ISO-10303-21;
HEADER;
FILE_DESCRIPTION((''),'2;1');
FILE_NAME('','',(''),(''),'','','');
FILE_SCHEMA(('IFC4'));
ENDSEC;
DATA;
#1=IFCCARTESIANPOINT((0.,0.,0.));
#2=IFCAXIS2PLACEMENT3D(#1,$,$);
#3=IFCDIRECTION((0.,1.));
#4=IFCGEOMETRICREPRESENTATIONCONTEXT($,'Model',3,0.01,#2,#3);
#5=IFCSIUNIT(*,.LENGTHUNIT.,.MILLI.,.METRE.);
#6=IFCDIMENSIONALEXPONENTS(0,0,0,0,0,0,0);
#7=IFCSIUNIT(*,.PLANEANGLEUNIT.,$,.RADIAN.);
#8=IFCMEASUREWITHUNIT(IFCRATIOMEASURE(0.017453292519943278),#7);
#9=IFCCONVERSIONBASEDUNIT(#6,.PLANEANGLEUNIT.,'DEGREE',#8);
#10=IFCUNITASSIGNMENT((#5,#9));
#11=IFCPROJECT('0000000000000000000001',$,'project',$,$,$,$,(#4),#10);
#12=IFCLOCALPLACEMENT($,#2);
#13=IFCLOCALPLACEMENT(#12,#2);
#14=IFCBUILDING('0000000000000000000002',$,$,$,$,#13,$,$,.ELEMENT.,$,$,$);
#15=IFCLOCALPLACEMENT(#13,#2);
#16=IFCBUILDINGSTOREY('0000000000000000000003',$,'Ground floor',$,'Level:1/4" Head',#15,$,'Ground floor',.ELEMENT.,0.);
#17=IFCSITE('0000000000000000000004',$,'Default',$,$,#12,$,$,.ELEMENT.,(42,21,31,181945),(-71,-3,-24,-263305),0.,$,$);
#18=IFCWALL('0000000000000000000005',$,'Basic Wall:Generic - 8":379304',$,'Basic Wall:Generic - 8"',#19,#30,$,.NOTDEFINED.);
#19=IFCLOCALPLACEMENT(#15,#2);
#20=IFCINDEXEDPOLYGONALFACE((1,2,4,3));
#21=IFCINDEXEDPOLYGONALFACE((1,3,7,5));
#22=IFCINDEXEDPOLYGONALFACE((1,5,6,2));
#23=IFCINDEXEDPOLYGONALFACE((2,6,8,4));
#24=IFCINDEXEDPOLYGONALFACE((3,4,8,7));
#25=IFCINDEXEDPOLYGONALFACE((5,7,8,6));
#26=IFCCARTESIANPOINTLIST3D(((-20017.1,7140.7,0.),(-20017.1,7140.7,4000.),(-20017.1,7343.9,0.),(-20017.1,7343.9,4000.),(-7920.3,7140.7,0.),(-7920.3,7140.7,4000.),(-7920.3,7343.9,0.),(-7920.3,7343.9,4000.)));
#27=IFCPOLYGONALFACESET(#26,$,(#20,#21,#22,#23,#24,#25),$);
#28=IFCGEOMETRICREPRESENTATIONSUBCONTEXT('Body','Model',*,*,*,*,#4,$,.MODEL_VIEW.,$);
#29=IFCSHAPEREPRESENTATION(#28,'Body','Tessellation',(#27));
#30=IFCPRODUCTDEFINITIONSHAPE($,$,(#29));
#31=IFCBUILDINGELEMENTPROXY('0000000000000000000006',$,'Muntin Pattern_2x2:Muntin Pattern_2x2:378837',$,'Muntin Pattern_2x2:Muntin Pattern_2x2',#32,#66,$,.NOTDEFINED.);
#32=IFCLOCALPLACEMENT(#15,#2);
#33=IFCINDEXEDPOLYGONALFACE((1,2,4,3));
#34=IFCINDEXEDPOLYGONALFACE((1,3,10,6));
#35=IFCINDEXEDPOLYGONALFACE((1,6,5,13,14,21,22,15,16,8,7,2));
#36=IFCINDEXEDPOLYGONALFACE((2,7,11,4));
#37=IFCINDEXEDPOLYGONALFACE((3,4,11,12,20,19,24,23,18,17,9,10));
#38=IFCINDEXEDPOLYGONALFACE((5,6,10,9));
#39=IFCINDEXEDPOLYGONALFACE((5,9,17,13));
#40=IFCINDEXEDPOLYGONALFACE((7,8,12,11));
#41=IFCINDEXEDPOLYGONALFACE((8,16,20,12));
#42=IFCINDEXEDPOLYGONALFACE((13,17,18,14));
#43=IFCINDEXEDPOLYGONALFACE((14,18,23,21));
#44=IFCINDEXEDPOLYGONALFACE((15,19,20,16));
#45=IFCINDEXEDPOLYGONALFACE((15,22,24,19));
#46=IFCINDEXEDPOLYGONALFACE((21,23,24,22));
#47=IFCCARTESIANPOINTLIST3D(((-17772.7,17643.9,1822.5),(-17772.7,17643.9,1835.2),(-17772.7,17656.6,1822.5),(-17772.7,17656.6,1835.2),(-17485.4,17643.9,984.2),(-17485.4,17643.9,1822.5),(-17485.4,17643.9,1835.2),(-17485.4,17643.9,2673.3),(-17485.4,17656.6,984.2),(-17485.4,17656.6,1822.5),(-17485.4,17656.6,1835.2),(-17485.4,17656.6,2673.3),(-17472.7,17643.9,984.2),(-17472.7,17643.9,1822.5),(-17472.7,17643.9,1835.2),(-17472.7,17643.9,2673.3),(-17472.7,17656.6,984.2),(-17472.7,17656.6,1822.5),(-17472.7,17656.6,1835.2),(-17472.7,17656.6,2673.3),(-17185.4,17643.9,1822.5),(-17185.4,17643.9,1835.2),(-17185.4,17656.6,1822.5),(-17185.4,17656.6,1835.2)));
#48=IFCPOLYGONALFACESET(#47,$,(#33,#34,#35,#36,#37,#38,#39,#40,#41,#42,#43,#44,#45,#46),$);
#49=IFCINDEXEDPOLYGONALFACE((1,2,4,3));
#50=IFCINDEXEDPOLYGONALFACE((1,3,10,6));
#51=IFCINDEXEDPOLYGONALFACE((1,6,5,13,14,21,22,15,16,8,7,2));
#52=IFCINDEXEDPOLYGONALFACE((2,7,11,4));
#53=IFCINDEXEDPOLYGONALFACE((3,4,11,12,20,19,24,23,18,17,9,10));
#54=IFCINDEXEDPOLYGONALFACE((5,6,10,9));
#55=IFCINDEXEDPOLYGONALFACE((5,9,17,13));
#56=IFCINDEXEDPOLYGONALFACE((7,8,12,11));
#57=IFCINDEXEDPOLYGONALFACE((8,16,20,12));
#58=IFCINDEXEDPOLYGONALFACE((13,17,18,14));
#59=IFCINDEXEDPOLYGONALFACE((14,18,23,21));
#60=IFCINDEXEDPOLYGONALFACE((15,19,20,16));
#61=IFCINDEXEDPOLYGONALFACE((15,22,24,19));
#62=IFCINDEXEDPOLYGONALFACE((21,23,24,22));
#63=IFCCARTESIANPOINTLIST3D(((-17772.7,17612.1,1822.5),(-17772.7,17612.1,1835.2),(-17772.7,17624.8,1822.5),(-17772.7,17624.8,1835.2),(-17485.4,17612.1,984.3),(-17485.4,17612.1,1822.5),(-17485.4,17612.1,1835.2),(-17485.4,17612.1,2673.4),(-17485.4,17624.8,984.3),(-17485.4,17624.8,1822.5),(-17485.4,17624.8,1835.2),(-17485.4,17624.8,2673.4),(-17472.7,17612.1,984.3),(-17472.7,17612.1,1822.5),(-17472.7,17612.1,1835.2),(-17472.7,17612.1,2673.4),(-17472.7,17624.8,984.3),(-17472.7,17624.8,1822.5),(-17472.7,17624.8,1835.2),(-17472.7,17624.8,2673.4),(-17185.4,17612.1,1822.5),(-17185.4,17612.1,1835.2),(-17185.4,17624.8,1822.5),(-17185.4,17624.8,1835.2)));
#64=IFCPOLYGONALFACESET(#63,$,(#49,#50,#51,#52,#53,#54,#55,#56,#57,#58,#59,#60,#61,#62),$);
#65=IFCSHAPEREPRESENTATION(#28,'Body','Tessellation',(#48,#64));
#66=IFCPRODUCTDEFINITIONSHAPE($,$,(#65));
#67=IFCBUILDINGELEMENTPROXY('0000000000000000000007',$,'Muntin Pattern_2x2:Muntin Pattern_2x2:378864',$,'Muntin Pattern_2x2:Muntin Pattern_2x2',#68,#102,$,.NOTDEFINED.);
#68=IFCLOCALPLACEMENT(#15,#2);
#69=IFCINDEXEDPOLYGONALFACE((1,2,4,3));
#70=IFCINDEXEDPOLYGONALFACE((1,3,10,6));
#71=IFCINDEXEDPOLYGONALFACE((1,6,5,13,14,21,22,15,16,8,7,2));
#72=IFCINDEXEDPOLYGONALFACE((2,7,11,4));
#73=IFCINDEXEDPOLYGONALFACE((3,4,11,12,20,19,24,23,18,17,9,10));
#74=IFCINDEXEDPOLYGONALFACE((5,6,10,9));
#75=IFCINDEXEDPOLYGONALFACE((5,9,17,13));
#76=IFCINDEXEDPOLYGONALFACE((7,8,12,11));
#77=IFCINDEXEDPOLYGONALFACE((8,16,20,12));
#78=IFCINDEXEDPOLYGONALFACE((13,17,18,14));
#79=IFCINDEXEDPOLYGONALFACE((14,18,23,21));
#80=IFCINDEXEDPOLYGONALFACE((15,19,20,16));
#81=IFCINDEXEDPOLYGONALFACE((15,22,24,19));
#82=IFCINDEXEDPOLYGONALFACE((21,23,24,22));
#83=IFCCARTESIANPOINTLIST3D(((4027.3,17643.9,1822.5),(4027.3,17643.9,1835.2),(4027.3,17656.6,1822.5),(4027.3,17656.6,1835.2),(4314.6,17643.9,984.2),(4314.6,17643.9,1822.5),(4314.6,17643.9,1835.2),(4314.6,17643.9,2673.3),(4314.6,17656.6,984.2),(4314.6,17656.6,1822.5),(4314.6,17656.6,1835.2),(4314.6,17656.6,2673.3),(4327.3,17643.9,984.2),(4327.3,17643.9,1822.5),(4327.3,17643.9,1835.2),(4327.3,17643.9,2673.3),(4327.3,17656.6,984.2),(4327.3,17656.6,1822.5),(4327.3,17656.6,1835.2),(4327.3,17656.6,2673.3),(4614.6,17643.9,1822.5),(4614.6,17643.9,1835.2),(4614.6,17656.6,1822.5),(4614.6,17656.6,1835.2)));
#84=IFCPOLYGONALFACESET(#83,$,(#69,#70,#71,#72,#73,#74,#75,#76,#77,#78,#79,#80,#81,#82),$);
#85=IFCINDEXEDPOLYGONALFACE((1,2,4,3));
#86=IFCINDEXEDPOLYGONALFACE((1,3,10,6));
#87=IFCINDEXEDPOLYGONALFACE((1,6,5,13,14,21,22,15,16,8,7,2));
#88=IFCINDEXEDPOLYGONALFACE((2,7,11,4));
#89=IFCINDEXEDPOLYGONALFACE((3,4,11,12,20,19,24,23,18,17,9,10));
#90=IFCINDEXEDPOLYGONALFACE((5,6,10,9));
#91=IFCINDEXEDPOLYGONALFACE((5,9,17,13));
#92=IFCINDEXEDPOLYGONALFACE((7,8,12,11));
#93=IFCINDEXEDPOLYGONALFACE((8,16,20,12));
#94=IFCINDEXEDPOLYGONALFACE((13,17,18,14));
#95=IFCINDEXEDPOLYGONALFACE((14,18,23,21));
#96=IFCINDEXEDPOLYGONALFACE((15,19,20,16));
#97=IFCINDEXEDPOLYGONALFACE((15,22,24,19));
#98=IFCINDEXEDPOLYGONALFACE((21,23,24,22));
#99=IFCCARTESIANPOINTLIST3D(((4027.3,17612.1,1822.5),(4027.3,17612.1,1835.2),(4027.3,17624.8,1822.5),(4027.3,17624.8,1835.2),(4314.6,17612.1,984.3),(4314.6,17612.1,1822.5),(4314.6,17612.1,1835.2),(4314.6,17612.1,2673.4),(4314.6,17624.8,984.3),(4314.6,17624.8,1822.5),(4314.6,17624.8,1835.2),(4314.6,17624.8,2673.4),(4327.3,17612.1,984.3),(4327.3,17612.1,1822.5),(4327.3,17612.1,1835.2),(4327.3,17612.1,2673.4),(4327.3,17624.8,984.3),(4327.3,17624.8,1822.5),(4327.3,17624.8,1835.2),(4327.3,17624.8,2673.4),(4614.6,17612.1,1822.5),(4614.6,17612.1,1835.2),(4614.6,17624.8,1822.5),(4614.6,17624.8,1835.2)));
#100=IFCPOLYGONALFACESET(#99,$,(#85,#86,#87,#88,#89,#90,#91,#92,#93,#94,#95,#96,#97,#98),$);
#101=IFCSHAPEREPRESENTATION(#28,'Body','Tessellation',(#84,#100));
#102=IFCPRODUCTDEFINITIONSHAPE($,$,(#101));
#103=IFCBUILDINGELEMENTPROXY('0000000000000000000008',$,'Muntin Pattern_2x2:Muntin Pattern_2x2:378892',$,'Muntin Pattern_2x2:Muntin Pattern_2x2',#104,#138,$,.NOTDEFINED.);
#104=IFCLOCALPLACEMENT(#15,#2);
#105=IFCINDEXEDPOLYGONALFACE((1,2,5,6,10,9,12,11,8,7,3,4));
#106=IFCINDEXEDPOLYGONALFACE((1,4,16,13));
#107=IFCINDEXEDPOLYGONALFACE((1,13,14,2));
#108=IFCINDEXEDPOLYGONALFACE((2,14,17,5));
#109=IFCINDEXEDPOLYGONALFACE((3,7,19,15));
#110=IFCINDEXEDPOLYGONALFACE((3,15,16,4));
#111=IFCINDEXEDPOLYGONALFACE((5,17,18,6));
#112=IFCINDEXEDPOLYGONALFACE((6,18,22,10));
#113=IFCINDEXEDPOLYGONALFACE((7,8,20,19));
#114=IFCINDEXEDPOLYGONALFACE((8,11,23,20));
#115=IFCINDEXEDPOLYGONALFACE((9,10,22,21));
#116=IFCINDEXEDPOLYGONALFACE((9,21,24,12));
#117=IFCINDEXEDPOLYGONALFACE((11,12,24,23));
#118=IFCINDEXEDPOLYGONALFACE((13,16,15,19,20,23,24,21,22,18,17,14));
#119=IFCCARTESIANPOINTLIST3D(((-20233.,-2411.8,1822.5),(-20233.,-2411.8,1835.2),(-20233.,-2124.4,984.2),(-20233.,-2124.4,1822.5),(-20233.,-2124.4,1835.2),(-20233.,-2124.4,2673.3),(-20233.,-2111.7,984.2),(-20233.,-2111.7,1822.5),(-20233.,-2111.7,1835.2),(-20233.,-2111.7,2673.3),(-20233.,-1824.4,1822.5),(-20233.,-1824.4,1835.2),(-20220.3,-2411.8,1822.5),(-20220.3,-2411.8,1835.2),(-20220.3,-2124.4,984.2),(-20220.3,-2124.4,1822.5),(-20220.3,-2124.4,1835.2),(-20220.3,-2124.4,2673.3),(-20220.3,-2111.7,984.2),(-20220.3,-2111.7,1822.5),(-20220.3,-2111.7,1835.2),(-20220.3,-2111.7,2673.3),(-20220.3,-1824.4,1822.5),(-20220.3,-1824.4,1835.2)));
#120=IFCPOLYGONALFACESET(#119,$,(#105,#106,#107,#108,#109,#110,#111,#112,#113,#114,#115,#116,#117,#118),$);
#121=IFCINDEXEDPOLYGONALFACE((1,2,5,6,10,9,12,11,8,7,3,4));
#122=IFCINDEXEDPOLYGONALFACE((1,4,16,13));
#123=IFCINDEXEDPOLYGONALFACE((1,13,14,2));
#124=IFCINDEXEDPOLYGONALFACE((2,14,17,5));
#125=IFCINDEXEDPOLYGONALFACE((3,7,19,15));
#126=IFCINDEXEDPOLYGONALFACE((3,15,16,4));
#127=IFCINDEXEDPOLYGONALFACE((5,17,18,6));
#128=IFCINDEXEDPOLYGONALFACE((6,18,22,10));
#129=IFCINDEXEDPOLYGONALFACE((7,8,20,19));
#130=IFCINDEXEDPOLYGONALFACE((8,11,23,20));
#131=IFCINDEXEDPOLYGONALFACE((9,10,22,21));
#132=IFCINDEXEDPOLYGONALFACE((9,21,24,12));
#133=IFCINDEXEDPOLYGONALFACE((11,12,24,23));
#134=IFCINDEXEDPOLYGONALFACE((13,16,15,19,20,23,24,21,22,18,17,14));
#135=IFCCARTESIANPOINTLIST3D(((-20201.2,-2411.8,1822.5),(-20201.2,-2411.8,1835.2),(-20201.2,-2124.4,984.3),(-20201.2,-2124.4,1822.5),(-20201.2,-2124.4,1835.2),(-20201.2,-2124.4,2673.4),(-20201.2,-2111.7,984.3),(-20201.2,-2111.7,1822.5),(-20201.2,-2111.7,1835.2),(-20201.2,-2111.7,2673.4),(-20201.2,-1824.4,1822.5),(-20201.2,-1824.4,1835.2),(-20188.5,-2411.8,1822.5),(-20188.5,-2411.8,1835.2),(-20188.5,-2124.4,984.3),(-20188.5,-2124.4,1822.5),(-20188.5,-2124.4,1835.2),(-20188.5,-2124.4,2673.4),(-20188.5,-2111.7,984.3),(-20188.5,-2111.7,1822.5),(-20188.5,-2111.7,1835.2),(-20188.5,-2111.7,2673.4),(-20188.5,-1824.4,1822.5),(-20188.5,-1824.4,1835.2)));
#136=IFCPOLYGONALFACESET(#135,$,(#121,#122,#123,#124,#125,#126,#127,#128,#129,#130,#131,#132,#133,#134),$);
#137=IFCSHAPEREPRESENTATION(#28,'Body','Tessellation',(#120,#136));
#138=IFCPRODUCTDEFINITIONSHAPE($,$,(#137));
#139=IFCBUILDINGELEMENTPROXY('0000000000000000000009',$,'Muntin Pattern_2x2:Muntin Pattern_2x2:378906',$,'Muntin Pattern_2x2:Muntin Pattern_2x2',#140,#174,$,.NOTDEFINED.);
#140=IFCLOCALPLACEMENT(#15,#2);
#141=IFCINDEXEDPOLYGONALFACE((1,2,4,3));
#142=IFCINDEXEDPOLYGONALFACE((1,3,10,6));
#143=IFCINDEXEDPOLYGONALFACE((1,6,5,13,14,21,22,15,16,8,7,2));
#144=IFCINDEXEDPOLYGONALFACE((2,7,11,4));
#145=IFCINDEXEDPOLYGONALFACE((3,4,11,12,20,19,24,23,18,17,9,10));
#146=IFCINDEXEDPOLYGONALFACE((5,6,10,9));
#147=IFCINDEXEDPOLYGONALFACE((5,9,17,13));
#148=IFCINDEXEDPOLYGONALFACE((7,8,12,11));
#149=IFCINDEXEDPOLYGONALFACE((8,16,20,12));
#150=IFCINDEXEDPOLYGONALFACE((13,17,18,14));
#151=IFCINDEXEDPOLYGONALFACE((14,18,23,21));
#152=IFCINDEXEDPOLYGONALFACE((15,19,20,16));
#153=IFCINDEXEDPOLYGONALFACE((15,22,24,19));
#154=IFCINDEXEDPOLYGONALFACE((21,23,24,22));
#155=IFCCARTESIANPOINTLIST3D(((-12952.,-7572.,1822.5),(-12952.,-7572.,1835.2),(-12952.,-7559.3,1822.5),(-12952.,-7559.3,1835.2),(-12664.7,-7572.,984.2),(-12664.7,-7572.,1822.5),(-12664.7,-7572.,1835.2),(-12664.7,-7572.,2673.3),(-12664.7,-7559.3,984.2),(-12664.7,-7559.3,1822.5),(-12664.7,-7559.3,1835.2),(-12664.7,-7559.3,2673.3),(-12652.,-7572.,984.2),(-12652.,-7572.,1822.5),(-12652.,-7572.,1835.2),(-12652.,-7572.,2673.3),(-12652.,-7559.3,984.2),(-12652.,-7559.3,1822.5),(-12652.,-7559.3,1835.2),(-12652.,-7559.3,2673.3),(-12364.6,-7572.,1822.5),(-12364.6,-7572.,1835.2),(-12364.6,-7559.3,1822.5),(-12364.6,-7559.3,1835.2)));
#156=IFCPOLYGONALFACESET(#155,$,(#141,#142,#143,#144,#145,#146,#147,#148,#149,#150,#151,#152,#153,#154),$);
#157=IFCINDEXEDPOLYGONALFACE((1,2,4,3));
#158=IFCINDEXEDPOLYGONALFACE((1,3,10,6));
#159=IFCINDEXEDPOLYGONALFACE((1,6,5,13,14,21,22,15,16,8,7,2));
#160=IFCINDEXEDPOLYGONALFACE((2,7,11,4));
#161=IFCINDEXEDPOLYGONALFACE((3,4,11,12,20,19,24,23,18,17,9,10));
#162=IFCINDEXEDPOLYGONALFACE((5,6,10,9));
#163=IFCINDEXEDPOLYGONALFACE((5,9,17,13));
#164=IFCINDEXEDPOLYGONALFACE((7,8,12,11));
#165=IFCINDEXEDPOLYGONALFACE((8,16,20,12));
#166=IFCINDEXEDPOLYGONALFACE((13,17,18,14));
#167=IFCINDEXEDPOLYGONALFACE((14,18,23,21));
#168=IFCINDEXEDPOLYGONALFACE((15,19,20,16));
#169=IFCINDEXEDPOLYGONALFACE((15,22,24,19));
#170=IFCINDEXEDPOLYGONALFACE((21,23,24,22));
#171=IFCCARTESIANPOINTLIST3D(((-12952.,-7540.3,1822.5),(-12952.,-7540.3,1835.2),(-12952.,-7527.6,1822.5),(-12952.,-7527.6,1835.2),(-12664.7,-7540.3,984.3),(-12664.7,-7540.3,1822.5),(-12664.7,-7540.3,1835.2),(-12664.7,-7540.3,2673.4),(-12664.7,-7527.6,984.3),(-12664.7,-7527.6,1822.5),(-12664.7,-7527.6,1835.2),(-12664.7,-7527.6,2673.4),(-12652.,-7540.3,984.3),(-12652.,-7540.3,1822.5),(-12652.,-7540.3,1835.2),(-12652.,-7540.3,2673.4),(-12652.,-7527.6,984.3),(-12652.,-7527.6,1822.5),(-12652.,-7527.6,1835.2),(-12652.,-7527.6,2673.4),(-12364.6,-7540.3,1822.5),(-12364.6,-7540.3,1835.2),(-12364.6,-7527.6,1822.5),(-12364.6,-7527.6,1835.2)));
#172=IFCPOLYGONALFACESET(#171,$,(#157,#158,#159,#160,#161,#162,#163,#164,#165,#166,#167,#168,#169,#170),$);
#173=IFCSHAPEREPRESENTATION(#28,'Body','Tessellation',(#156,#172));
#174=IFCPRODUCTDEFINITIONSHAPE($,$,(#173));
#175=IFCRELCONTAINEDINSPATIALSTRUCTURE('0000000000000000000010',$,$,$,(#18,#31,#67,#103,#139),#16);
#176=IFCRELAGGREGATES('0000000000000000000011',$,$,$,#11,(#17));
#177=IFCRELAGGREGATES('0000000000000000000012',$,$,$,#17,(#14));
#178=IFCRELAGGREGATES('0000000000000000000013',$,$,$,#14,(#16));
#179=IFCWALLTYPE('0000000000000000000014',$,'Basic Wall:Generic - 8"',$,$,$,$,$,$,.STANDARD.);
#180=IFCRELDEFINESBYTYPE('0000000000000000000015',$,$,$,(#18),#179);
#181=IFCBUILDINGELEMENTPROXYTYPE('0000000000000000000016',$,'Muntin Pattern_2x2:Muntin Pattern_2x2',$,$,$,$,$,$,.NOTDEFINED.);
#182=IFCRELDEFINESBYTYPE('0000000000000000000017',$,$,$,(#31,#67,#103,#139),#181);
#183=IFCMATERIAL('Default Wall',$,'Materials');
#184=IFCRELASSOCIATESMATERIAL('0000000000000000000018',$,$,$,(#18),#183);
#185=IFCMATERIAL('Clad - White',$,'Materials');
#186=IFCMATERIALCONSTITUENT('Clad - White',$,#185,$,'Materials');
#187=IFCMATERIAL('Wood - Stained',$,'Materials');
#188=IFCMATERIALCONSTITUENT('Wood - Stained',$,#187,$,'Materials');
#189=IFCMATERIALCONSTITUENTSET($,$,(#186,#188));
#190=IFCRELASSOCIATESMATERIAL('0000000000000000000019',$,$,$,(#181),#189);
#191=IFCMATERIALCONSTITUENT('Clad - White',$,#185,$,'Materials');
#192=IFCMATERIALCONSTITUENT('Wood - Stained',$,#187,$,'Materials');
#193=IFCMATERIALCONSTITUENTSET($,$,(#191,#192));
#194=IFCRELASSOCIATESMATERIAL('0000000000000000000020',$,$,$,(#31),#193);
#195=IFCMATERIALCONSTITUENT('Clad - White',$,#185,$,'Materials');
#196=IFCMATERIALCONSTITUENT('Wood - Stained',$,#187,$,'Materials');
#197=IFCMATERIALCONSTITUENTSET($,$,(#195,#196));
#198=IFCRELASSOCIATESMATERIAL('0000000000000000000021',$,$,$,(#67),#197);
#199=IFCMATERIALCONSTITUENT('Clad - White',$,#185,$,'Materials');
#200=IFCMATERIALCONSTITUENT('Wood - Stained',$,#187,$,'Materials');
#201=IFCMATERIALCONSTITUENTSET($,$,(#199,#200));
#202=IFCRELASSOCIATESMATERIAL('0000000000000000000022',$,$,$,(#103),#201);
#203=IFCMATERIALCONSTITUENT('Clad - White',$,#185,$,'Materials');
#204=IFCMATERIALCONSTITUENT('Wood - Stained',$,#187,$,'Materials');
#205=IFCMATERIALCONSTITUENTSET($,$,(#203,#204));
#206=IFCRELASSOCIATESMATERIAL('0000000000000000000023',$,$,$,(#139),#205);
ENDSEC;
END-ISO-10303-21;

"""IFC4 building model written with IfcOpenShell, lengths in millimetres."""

from ifc_helpers import new_model, entity, si_unit, converted_unit, direction, frame, origin, place, context, subcontext, project, spatial, indexed_curve, outline, extrude, source, transform, mapped, material, constituent, constituent_set, type_object, type_shapes, element, save


model = new_model("IFC4")

# Units and contexts
model_context = context("Model", 3, precision=0.01, world=origin(), true_north=direction((0.0, 1.0)))
body_context = subcontext(model_context, "Body", "Model", "MODEL_VIEW")
ifc_project = project(units=[si_unit("LENGTHUNIT", "METRE", prefix="MILLI"), converted_unit("PLANEANGLEUNIT", "DEGREE", entity("IfcRatioMeasure", 0.017453292519943278), si_unit("PLANEANGLEUNIT", "RADIAN"), dimensions=[0, 0, 0, 0, 0, 0, 0])], contexts=[model_context])

# Site, building, storey
site_placement = place(None, origin())
site = spatial("IfcSite", under=ifc_project, at=site_placement, Name="Default", CompositionType="ELEMENT", RefLatitude=(42, 21, 31, 181945), RefLongitude=(-71, -3, -24, -263305), RefElevation=0.0)
building_placement = place(site_placement, origin())
building = spatial("IfcBuilding", under=site, at=building_placement, CompositionType="ELEMENT")
storey_placement = place(building_placement, origin())
storey = spatial("IfcBuildingStorey", under=building, at=storey_placement, Name="Ground floor", ObjectType="Level:1/4\" Head", LongName="Ground floor", CompositionType="ELEMENT", Elevation=0.0)

# Wall
ifc_material_1 = material(Name="Default Wall", Category="Materials")
wall_type = type_object("IfcWallType", Name="Basic Wall:Generic - 8\"", PredefinedType="STANDARD")
wall_placement = place(storey_placement, frame((-20017.1, 7242.3, 0.0)))
element("IfcWall", 1, at=wall_placement, inside=storey, type_object=wall_type, material=ifc_material_1, Name="Basic Wall:Generic - 8\":379304", ObjectType="Basic Wall:Generic - 8\"", PredefinedType="NOTDEFINED", context=body_context, shape_type="SweptSolid", body=[
    extrude(outline(indexed_curve([(12096.8, 101.6), (0.0, 101.6), (0.0, -101.6), (12096.8, -101.6), (12096.8, 101.6)], self_intersect=False)), origin(), (0.0, 0.0, 1.0), 4000.0),
])

# Building element proxies
ifc_material_2 = material(Name="Clad - White", Category="Materials")
ifc_constituent_1 = constituent(ifc_material_2, Name="Clad - White", Category="Materials")
ifc_material_3 = material(Name="Wood - Stained", Category="Materials")
ifc_constituent_2 = constituent(ifc_material_3, Name="Wood - Stained", Category="Materials")
ifc_constituent_set_1 = constituent_set(constituents=[ifc_constituent_1, ifc_constituent_2])
ifc_constituent_3 = constituent(ifc_material_2, Name="Clad - White", Category="Materials")
ifc_constituent_4 = constituent(ifc_material_3, Name="Wood - Stained", Category="Materials")
ifc_constituent_set_2 = constituent_set(constituents=[ifc_constituent_3, ifc_constituent_4])
building_element_proxy_type_1 = type_object("IfcBuildingElementProxyType", Name="Muntin Pattern_2x2:Muntin Pattern_2x2", PredefinedType="NOTDEFINED", material=ifc_constituent_set_2)
shared_shape_1 = source(origin(), body_context, "Body", "SweptSolid", [
    extrude(outline(indexed_curve([(6.4, -6.4), (844.5, -6.4), (844.5, 6.3), (6.4, 6.3), (6.4, 293.7), (-6.3, 293.7), (-6.3, 6.3), (-844.6, 6.3), (-844.6, -6.4), (-6.3, -6.4), (-6.3, -293.7), (6.4, -293.7), (6.4, -6.4)], self_intersect=False)), frame((0.0, 9.5, 844.5), z_axis=(0.0, 1.0, 0.0), x_axis=(0.0, 0.0, 1.0)), (0.0, 0.0, 1.0), 12.7),
    extrude(outline(indexed_curve([(6.4, -6.4), (844.6, -6.4), (844.6, 6.3), (6.4, 6.3), (6.4, 293.7), (-6.3, 293.7), (-6.3, 6.3), (-844.6, 6.3), (-844.6, -6.4), (-6.3, -6.4), (-6.3, -293.7), (6.4, -293.7), (6.4, -6.4)], self_intersect=False)), frame((0.0, -22.2, 844.6), z_axis=(0.0, 1.0, 0.0), x_axis=(0.0, 0.0, 1.0)), (0.0, 0.0, 1.0), 12.7),
])
type_shapes(building_element_proxy_type_1, [shared_shape_1])
proxy_1_placement = place(storey_placement, frame((-17479.1, 17634.3, 984.3)))
element("IfcBuildingElementProxy", 2, at=proxy_1_placement, inside=storey, type_object=building_element_proxy_type_1, material=ifc_constituent_set_1, Name="Muntin Pattern_2x2:Muntin Pattern_2x2:378837", ObjectType="Muntin Pattern_2x2:Muntin Pattern_2x2", PredefinedType="NOTDEFINED", context=body_context, shape_type="MappedRepresentation", body=[
    mapped(shared_shape_1, transform((0.0, 0.0, 0.0), scale=1.0)),
])
ifc_constituent_5 = constituent(ifc_material_2, Name="Clad - White", Category="Materials")
ifc_constituent_6 = constituent(ifc_material_3, Name="Wood - Stained", Category="Materials")
ifc_constituent_set_3 = constituent_set(constituents=[ifc_constituent_5, ifc_constituent_6])
proxy_2_placement = place(storey_placement, frame((4320.9, 17634.3, 984.3)))
element("IfcBuildingElementProxy", 3, at=proxy_2_placement, inside=storey, type_object=building_element_proxy_type_1, material=ifc_constituent_set_3, Name="Muntin Pattern_2x2:Muntin Pattern_2x2:378864", ObjectType="Muntin Pattern_2x2:Muntin Pattern_2x2", PredefinedType="NOTDEFINED", context=body_context, shape_type="MappedRepresentation", body=[
    mapped(shared_shape_1, transform((0.0, 0.0, 0.0), scale=1.0)),
])
ifc_constituent_7 = constituent(ifc_material_2, Name="Clad - White", Category="Materials")
ifc_constituent_8 = constituent(ifc_material_3, Name="Wood - Stained", Category="Materials")
ifc_constituent_set_4 = constituent_set(constituents=[ifc_constituent_7, ifc_constituent_8])
proxy_3_placement = place(storey_placement, frame((-20210.8, -2118.1, 984.3), z_axis=(0.0, 0.0, 1.0), x_axis=(0.0, 1.0, 0.0)))
element("IfcBuildingElementProxy", 4, at=proxy_3_placement, inside=storey, type_object=building_element_proxy_type_1, material=ifc_constituent_set_4, Name="Muntin Pattern_2x2:Muntin Pattern_2x2:378892", ObjectType="Muntin Pattern_2x2:Muntin Pattern_2x2", PredefinedType="NOTDEFINED", context=body_context, shape_type="MappedRepresentation", body=[
    mapped(shared_shape_1, transform((0.0, 0.0, 0.0), scale=1.0)),
])
ifc_constituent_9 = constituent(ifc_material_2, Name="Clad - White", Category="Materials")
ifc_constituent_10 = constituent(ifc_material_3, Name="Wood - Stained", Category="Materials")
ifc_constituent_set_5 = constituent_set(constituents=[ifc_constituent_9, ifc_constituent_10])
proxy_4_placement = place(storey_placement, frame((-12658.3, -7549.8, 984.3), z_axis=(0.0, 0.0, 1.0), x_axis=(-1.0, 0.0, 0.0)))
element("IfcBuildingElementProxy", 5, at=proxy_4_placement, inside=storey, type_object=building_element_proxy_type_1, material=ifc_constituent_set_5, Name="Muntin Pattern_2x2:Muntin Pattern_2x2:378906", ObjectType="Muntin Pattern_2x2:Muntin Pattern_2x2", PredefinedType="NOTDEFINED", context=body_context, shape_type="MappedRepresentation", body=[
    mapped(shared_shape_1, transform((0.0, 0.0, 0.0), scale=1.0)),
])

save(model, "model.ifc")
